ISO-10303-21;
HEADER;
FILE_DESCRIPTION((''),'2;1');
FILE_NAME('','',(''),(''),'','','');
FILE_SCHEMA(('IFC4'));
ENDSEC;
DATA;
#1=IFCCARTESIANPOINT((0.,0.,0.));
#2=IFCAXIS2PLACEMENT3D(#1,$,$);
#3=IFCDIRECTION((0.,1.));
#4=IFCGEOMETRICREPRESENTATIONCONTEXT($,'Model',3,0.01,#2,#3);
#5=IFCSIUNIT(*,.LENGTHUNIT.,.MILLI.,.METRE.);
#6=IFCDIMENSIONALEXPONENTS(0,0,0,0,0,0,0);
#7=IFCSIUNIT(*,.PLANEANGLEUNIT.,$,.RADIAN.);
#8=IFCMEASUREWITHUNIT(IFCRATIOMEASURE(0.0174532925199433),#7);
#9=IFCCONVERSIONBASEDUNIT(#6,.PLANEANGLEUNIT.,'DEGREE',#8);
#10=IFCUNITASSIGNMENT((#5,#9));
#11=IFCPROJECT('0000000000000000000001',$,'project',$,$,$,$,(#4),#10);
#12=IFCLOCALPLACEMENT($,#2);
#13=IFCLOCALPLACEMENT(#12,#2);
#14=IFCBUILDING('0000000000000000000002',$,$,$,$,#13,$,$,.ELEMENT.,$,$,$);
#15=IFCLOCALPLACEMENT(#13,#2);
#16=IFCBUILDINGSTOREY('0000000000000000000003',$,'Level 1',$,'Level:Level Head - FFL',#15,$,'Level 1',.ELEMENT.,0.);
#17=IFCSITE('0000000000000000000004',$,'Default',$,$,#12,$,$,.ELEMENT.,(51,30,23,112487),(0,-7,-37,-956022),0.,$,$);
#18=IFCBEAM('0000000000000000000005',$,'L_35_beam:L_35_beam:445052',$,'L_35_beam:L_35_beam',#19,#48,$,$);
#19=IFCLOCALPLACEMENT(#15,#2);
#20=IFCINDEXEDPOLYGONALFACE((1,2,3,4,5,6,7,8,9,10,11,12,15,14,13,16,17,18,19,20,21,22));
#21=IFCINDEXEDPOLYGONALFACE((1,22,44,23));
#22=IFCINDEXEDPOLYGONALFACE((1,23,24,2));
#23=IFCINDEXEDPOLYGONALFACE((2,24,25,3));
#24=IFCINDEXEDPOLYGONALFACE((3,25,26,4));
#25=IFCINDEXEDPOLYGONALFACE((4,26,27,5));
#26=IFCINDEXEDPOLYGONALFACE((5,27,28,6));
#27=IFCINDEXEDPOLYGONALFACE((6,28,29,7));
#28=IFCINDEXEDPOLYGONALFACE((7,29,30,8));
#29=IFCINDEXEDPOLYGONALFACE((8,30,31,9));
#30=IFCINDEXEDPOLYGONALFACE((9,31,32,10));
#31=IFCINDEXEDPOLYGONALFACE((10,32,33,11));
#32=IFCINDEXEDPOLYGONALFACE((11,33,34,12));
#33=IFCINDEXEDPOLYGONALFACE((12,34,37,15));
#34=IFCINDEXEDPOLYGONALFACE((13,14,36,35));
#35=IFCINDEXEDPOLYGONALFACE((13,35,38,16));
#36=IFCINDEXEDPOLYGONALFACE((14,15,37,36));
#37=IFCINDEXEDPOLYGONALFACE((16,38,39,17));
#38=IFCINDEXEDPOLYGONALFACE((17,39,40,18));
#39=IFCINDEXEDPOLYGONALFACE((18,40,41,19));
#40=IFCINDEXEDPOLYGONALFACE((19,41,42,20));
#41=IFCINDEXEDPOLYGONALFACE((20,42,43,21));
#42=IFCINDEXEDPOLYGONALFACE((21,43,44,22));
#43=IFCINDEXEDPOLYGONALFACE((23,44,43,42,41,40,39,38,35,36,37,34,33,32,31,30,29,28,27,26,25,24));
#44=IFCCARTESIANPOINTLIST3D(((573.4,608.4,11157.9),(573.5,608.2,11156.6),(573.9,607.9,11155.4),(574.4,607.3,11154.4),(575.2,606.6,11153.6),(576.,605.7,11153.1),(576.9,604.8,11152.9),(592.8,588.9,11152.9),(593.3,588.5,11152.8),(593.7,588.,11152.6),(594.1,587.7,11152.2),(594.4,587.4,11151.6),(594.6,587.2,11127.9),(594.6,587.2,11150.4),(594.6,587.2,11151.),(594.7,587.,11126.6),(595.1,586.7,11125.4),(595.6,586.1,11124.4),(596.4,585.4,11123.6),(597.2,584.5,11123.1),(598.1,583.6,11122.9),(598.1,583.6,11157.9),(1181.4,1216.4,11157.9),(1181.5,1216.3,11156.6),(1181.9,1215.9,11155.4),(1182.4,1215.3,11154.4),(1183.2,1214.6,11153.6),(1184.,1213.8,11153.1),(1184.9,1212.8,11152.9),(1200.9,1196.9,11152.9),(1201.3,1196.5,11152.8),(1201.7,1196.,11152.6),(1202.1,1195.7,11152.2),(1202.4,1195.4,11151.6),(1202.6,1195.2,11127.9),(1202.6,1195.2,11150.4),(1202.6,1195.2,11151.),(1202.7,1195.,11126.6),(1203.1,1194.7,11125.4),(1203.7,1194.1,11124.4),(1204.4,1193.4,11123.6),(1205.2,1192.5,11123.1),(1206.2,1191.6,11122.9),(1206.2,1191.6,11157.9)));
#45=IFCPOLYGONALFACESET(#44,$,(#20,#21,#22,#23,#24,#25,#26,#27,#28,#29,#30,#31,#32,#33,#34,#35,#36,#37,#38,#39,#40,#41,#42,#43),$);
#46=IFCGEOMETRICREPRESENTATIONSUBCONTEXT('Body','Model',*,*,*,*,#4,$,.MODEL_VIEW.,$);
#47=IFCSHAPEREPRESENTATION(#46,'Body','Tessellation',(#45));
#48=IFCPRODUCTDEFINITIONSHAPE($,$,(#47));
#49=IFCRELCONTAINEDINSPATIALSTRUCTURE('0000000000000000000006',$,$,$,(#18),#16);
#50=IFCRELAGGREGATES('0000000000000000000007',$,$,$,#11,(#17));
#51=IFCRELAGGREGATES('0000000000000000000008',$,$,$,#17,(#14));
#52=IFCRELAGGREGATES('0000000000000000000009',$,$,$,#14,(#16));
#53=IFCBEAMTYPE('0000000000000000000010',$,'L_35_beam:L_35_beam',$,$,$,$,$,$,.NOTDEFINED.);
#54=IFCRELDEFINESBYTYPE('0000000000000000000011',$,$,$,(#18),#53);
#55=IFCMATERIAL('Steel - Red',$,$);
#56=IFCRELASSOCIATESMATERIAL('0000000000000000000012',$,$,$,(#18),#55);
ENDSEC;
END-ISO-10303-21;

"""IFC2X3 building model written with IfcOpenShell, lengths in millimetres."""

from ifc_helpers import new_model, entity, si_unit, converted_unit, direction, frame, frame_2d, origin, place, context, subcontext, project, spatial, polyline, circle_curve, parameter, trimmed, segment, composite_curve, outline, extrude, material, type_object, element, save


model = new_model("IFC2X3")

# Units and contexts
model_context = context("Model", 3, precision=0.01, world=origin(), true_north=direction((0.0, 1.0)))
body_context = subcontext(model_context, "Body", "Model", "MODEL_VIEW")
ifc_project = project(units=[si_unit("LENGTHUNIT", "METRE", prefix="MILLI"), converted_unit("PLANEANGLEUNIT", "DEGREE", entity("IfcRatioMeasure", 0.0174532925199433), si_unit("PLANEANGLEUNIT", "RADIAN"), dimensions=[0, 0, 0, 0, 0, 0, 0])], contexts=[model_context])

# Site, building, storey
site_placement = place(None, origin())
site = spatial("IfcSite", under=ifc_project, at=site_placement, Name="Default", CompositionType="ELEMENT", RefLatitude=(51, 30, 23, 112487), RefLongitude=(0, -7, -37, -956022), RefElevation=0.0)
building_placement = place(site_placement, origin())
building = spatial("IfcBuilding", under=site, at=building_placement, CompositionType="ELEMENT")
storey_placement = place(building_placement, origin())
storey = spatial("IfcBuildingStorey", under=building, at=storey_placement, Name="Level 1", ObjectType="Level:Level Head - FFL", LongName="Level 1", CompositionType="ELEMENT", Elevation=0.0)

# Beam
ifc_material_1 = material(Name="Steel - Red")
beam_type_1 = type_object("IfcBeamType", Name="L_35_beam:L_35_beam", PredefinedType="NOTDEFINED")
beam_1_placement = place(storey_placement, frame((1238.5, 1238.5, 11147.6), z_axis=(0.0, 0.0, 1.0), x_axis=(-0.707107, -0.707107, 0.0)))
element("IfcBeam", 1, at=beam_1_placement, inside=storey, type_object=beam_type_1, material=ifc_material_1, Name="L_35_beam:L_35_beam:445052", ObjectType="L_35_beam:L_35_beam", context=body_context, shape_type="SweptSolid", body=[
    extrude(outline(composite_curve([segment(polyline([(-23.2, -11.8), (11.8, -11.8)]), True, "CONTINUOUS"), segment(polyline([(11.8, -11.8), (11.8, 23.2)]), True, "CONTINUOUS"), segment(trimmed(circle_curve(frame_2d((11.8, 18.2), x_axis=(0.0, 1.0)), 5.0), [parameter(0.0)], [parameter(90.0)], True, "PARAMETER"), True, "CONTINUOUS"), segment(polyline([(6.8, 18.2), (6.8, -4.3)]), True, "CONTINUOUS"), segment(trimmed(circle_curve(frame_2d((4.3, -4.3), x_axis=(1.0, 0.0)), 2.5), [parameter(270.0)], [parameter(0.0)], True, "PARAMETER"), False, "CONTINUOUS"), segment(polyline([(4.3, -6.8), (-18.2, -6.8)]), True, "CONTINUOUS"), segment(trimmed(circle_curve(frame_2d((-18.2, -11.8), x_axis=(0.0, 1.0)), 5.0), [parameter(0.0)], [parameter(90.0)], True, "PARAMETER"), True, "CONTINUOUS")], self_intersect=False)), frame((56.0, -1.5, -1.5), z_axis=(1.0, 0.0, 0.0), x_axis=(0.0, 0.0, 1.0)), (0.0, 0.0, 1.0), 859.9),
])

save(model, "model.ifc")
